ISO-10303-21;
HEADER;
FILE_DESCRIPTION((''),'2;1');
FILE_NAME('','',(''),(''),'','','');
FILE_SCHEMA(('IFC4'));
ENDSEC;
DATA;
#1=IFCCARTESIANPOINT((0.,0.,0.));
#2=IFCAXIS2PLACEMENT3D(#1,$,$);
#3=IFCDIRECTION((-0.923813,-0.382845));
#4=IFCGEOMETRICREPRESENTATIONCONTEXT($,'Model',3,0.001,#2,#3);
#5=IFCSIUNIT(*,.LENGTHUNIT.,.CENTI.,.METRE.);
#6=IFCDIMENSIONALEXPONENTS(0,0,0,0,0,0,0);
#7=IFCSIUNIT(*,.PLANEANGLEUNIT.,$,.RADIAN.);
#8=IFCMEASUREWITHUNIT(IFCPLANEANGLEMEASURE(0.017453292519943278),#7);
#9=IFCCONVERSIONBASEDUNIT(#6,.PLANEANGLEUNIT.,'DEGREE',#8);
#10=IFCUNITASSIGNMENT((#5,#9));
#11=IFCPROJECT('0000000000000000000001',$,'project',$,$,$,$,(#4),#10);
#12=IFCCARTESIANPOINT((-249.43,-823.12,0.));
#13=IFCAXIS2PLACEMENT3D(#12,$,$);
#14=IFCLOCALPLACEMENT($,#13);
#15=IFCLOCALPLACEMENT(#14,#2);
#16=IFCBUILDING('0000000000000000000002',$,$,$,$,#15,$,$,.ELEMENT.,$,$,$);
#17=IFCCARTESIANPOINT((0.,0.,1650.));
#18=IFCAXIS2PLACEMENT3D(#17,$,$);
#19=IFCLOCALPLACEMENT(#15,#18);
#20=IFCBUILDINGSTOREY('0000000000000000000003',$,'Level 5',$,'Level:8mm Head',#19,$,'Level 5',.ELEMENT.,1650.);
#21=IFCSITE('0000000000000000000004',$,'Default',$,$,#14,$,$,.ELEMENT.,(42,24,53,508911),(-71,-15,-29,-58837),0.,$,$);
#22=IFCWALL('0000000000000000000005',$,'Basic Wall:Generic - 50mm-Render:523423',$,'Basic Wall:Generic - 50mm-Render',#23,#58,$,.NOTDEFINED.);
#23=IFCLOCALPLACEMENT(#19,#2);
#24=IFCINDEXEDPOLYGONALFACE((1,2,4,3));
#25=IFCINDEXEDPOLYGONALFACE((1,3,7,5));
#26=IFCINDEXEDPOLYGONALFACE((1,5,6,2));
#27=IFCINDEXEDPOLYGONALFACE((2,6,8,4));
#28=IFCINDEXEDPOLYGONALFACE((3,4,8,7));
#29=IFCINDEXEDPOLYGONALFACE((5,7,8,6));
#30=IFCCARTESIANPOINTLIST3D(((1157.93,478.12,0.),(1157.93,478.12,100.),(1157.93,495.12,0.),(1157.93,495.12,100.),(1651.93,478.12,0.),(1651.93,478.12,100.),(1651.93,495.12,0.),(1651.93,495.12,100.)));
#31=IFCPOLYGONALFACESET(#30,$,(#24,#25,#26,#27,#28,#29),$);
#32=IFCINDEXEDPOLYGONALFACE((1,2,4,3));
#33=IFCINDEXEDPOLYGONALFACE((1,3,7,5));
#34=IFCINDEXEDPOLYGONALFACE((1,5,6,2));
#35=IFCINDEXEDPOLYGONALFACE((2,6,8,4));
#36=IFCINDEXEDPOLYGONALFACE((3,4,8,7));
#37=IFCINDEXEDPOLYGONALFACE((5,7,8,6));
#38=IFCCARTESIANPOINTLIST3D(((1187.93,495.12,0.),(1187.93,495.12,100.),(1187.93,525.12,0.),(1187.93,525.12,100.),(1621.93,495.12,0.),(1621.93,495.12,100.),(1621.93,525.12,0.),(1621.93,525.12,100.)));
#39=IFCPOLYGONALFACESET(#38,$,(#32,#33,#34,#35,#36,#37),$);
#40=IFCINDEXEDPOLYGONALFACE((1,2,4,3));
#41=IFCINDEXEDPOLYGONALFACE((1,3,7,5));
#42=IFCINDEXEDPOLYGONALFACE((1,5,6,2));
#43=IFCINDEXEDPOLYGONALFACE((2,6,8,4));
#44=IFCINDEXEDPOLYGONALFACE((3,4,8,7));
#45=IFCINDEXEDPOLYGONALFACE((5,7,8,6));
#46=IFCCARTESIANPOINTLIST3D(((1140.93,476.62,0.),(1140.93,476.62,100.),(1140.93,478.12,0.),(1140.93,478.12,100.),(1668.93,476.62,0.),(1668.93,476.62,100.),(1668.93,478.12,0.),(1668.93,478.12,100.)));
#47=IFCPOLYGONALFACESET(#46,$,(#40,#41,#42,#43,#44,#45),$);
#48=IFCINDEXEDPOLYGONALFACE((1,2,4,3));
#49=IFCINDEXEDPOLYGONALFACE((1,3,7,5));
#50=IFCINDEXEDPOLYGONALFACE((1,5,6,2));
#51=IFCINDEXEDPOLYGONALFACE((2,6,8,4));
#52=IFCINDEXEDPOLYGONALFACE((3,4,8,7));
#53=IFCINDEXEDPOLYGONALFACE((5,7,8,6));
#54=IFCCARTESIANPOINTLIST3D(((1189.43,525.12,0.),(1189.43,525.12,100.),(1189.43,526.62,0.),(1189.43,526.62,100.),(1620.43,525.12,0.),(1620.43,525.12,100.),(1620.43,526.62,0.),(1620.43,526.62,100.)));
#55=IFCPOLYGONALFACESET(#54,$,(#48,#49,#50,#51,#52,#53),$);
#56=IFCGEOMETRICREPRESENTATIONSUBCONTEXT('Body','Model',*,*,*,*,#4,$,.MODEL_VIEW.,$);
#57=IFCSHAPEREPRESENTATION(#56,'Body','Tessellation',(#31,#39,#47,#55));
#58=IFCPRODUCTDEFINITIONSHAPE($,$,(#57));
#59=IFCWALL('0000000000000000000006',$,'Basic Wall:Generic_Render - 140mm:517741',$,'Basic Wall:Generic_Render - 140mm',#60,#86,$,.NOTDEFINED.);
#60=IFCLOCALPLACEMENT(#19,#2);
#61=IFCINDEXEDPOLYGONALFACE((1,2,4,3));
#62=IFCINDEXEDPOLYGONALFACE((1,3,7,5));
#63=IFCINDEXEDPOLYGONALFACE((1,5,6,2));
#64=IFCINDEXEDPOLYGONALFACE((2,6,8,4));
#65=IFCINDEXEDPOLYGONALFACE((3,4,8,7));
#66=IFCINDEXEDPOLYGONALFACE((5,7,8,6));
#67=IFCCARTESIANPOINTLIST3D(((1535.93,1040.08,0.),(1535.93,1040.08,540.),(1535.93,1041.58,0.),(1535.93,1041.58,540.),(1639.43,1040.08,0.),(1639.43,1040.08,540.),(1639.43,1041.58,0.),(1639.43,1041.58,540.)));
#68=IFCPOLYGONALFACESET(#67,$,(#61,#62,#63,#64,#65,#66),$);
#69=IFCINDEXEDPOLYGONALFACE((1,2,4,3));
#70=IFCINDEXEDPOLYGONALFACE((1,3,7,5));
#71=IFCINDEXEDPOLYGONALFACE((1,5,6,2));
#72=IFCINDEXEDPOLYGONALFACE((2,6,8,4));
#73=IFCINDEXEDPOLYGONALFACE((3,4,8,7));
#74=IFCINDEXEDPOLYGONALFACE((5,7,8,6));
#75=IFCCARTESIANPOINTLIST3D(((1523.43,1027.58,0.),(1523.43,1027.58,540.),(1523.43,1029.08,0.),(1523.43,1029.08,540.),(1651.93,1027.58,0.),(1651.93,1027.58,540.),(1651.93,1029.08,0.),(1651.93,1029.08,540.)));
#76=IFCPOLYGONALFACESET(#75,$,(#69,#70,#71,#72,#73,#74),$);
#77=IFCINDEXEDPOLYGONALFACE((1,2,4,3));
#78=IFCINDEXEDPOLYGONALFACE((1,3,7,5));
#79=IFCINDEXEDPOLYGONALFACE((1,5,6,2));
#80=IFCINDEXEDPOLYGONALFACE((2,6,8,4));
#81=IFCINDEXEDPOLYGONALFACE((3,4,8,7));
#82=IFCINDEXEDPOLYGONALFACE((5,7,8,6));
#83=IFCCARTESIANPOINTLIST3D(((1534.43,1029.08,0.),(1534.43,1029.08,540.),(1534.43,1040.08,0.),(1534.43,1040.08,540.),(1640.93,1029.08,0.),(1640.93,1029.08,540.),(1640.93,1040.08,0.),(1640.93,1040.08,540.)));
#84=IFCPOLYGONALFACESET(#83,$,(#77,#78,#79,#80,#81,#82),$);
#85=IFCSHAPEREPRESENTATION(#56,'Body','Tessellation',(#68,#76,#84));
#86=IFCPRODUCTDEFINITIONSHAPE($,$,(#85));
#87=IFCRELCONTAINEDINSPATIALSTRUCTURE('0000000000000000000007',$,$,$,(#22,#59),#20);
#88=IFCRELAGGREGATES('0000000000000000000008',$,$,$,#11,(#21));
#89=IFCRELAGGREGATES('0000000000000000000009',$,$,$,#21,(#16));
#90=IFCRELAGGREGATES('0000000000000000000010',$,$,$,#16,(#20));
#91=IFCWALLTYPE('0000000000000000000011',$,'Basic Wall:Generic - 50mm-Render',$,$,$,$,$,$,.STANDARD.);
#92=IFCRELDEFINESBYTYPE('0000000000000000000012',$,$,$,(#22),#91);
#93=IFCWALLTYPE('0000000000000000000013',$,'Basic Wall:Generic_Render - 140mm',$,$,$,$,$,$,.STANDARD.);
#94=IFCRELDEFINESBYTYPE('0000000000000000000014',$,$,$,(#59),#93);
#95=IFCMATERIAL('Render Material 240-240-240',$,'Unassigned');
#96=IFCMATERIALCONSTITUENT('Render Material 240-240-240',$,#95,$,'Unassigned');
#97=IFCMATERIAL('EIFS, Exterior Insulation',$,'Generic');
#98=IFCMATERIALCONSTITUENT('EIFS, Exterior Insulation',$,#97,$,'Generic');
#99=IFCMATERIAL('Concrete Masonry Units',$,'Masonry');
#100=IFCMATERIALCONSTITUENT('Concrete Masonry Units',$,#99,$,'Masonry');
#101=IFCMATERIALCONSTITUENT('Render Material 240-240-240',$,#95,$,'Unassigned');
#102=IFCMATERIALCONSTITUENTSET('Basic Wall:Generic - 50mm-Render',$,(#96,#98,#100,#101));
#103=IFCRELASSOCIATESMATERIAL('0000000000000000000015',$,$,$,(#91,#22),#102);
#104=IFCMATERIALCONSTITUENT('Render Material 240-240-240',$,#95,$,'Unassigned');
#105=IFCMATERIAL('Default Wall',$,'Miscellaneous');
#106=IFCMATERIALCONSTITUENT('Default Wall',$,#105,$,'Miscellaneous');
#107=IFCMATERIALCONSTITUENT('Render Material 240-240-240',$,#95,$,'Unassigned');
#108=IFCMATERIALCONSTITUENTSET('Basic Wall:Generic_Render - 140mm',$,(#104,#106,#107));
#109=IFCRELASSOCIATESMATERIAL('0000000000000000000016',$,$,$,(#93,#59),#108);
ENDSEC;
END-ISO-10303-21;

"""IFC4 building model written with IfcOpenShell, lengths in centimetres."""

from ifc_helpers import new_model, entity, si_unit, converted_unit, direction, frame, origin, place, context, subcontext, project, spatial, indexed_curve, outline, extrude, material, constituent, constituent_set, type_object, element, save


model = new_model("IFC4")

# Units and contexts
model_context = context("Model", 3, precision=0.001, world=origin(), true_north=direction((-0.923813, -0.382845)))
body_context = subcontext(model_context, "Body", "Model", "MODEL_VIEW")
ifc_project = project(units=[si_unit("LENGTHUNIT", "METRE", prefix="CENTI"), converted_unit("PLANEANGLEUNIT", "DEGREE", entity("IfcPlaneAngleMeasure", 0.017453292519943278), si_unit("PLANEANGLEUNIT", "RADIAN"), dimensions=[0, 0, 0, 0, 0, 0, 0])], contexts=[model_context])

# Site, building, storey
site_placement = place(None, frame((-249.43, -823.12, 0.0)))
site = spatial("IfcSite", under=ifc_project, at=site_placement, Name="Default", CompositionType="ELEMENT", RefLatitude=(42, 24, 53, 508911), RefLongitude=(-71, -15, -29, -58837), RefElevation=0.0)
building_placement = place(site_placement, origin())
building = spatial("IfcBuilding", under=site, at=building_placement, CompositionType="ELEMENT")
storey_placement = place(building_placement, frame((0.0, 0.0, 1650.0)))
storey = spatial("IfcBuildingStorey", under=building, at=storey_placement, Name="Level 5", ObjectType="Level:8mm Head", LongName="Level 5", CompositionType="ELEMENT", Elevation=1650.0)

# Walls
ifc_material_1 = material(Name="Render Material 240-240-240", Category="Unassigned")
ifc_constituent_1 = constituent(ifc_material_1, Name="Render Material 240-240-240", Category="Unassigned")
ifc_material_2 = material(Name="EIFS, Exterior Insulation", Category="Generic")
ifc_constituent_2 = constituent(ifc_material_2, Name="EIFS, Exterior Insulation", Category="Generic")
ifc_material_3 = material(Name="Concrete Masonry Units", Category="Masonry")
ifc_constituent_3 = constituent(ifc_material_3, Name="Concrete Masonry Units", Category="Masonry")
ifc_constituent_4 = constituent(ifc_material_1, Name="Render Material 240-240-240", Category="Unassigned")
ifc_constituent_set_1 = constituent_set(constituents=[ifc_constituent_1, ifc_constituent_2, ifc_constituent_3, ifc_constituent_4], Name="Basic Wall:Generic - 50mm-Render")
wall_type_1 = type_object("IfcWallType", Name="Basic Wall:Generic - 50mm-Render", PredefinedType="STANDARD", material=ifc_constituent_set_1)
wall_1_placement = place(storey_placement, frame((1620.43, 501.62, 0.0), z_axis=(0.0, 0.0, 1.0), x_axis=(-1.0, 0.0, 0.0)))
element("IfcWall", 1, at=wall_1_placement, inside=storey, type_object=wall_type_1, material=ifc_constituent_set_1, Name="Basic Wall:Generic - 50mm-Render:523423", ObjectType="Basic Wall:Generic - 50mm-Render", PredefinedType="NOTDEFINED", context=body_context, shape_type="SweptSolid", body=[
    extrude(outline(indexed_curve([(-247.0, -8.5), (247.0, -8.5), (247.0, 8.5), (-247.0, 8.5), (-247.0, -8.5)], self_intersect=False)), frame((215.5, 15.0, 0.0)), (0.0, 0.0, 1.0), 100.0),
    extrude(outline(indexed_curve([(-217.0, -15.0), (217.0, -15.0), (217.0, 15.0), (-217.0, 15.0), (-217.0, -15.0)], self_intersect=False)), frame((215.5, -8.5, 0.0)), (0.0, 0.0, 1.0), 100.0),
    extrude(outline(indexed_curve([(-0.75, -264.0), (0.75, -264.0), (0.75, 264.0), (-0.75, 264.0), (-0.75, -264.0)], self_intersect=False)), frame((215.5, 24.25, 0.0), z_axis=(0.0, 0.0, 1.0), x_axis=(0.0, -1.0, 0.0)), (0.0, 0.0, 1.0), 100.0),
    extrude(outline(indexed_curve([(-0.75, -215.5), (0.75, -215.5), (0.75, 215.5), (-0.75, 215.5), (-0.75, -215.5)], self_intersect=False)), frame((215.5, -24.25, 0.0), z_axis=(0.0, 0.0, 1.0), x_axis=(0.0, 1.0, 0.0)), (0.0, 0.0, 1.0), 100.0),
])
ifc_constituent_5 = constituent(ifc_material_1, Name="Render Material 240-240-240", Category="Unassigned")
ifc_material_4 = material(Name="Default Wall", Category="Miscellaneous")
ifc_constituent_6 = constituent(ifc_material_4, Name="Default Wall", Category="Miscellaneous")
ifc_constituent_7 = constituent(ifc_material_1, Name="Render Material 240-240-240", Category="Unassigned")
ifc_constituent_set_2 = constituent_set(constituents=[ifc_constituent_5, ifc_constituent_6, ifc_constituent_7], Name="Basic Wall:Generic_Render - 140mm")
wall_type_2 = type_object("IfcWallType", Name="Basic Wall:Generic_Render - 140mm", PredefinedType="STANDARD", material=ifc_constituent_set_2)
wall_2_placement = place(storey_placement, frame((1535.93, 1034.58, 0.0)))
element("IfcWall", 2, at=wall_2_placement, inside=storey, type_object=wall_type_2, material=ifc_constituent_set_2, Name="Basic Wall:Generic_Render - 140mm:517741", ObjectType="Basic Wall:Generic_Render - 140mm", PredefinedType="NOTDEFINED", context=body_context, shape_type="SweptSolid", body=[
    extrude(outline(indexed_curve([(-0.75, -51.75), (0.75, -51.75), (0.75, 51.75), (-0.75, 51.75), (-0.75, -51.75)], self_intersect=False)), frame((51.75, 6.25, 0.0), z_axis=(0.0, 0.0, 1.0), x_axis=(0.0, -1.0, 0.0)), (0.0, 0.0, 1.0), 540.0),
    extrude(outline(indexed_curve([(-0.75, -64.25), (0.75, -64.25), (0.75, 64.25), (-0.75, 64.25), (-0.75, -64.25)], self_intersect=False)), frame((51.75, -6.25, 0.0), z_axis=(0.0, 0.0, 1.0), x_axis=(0.0, 1.0, 0.0)), (0.0, 0.0, 1.0), 540.0),
    extrude(outline(indexed_curve([(-53.25, -5.5), (53.25, -5.5), (53.25, 5.5), (-53.25, 5.5), (-53.25, -5.5)], self_intersect=False)), frame((51.75, 0.0, 0.0)), (0.0, 0.0, 1.0), 540.0),
])

save(model, "model.ifc")
